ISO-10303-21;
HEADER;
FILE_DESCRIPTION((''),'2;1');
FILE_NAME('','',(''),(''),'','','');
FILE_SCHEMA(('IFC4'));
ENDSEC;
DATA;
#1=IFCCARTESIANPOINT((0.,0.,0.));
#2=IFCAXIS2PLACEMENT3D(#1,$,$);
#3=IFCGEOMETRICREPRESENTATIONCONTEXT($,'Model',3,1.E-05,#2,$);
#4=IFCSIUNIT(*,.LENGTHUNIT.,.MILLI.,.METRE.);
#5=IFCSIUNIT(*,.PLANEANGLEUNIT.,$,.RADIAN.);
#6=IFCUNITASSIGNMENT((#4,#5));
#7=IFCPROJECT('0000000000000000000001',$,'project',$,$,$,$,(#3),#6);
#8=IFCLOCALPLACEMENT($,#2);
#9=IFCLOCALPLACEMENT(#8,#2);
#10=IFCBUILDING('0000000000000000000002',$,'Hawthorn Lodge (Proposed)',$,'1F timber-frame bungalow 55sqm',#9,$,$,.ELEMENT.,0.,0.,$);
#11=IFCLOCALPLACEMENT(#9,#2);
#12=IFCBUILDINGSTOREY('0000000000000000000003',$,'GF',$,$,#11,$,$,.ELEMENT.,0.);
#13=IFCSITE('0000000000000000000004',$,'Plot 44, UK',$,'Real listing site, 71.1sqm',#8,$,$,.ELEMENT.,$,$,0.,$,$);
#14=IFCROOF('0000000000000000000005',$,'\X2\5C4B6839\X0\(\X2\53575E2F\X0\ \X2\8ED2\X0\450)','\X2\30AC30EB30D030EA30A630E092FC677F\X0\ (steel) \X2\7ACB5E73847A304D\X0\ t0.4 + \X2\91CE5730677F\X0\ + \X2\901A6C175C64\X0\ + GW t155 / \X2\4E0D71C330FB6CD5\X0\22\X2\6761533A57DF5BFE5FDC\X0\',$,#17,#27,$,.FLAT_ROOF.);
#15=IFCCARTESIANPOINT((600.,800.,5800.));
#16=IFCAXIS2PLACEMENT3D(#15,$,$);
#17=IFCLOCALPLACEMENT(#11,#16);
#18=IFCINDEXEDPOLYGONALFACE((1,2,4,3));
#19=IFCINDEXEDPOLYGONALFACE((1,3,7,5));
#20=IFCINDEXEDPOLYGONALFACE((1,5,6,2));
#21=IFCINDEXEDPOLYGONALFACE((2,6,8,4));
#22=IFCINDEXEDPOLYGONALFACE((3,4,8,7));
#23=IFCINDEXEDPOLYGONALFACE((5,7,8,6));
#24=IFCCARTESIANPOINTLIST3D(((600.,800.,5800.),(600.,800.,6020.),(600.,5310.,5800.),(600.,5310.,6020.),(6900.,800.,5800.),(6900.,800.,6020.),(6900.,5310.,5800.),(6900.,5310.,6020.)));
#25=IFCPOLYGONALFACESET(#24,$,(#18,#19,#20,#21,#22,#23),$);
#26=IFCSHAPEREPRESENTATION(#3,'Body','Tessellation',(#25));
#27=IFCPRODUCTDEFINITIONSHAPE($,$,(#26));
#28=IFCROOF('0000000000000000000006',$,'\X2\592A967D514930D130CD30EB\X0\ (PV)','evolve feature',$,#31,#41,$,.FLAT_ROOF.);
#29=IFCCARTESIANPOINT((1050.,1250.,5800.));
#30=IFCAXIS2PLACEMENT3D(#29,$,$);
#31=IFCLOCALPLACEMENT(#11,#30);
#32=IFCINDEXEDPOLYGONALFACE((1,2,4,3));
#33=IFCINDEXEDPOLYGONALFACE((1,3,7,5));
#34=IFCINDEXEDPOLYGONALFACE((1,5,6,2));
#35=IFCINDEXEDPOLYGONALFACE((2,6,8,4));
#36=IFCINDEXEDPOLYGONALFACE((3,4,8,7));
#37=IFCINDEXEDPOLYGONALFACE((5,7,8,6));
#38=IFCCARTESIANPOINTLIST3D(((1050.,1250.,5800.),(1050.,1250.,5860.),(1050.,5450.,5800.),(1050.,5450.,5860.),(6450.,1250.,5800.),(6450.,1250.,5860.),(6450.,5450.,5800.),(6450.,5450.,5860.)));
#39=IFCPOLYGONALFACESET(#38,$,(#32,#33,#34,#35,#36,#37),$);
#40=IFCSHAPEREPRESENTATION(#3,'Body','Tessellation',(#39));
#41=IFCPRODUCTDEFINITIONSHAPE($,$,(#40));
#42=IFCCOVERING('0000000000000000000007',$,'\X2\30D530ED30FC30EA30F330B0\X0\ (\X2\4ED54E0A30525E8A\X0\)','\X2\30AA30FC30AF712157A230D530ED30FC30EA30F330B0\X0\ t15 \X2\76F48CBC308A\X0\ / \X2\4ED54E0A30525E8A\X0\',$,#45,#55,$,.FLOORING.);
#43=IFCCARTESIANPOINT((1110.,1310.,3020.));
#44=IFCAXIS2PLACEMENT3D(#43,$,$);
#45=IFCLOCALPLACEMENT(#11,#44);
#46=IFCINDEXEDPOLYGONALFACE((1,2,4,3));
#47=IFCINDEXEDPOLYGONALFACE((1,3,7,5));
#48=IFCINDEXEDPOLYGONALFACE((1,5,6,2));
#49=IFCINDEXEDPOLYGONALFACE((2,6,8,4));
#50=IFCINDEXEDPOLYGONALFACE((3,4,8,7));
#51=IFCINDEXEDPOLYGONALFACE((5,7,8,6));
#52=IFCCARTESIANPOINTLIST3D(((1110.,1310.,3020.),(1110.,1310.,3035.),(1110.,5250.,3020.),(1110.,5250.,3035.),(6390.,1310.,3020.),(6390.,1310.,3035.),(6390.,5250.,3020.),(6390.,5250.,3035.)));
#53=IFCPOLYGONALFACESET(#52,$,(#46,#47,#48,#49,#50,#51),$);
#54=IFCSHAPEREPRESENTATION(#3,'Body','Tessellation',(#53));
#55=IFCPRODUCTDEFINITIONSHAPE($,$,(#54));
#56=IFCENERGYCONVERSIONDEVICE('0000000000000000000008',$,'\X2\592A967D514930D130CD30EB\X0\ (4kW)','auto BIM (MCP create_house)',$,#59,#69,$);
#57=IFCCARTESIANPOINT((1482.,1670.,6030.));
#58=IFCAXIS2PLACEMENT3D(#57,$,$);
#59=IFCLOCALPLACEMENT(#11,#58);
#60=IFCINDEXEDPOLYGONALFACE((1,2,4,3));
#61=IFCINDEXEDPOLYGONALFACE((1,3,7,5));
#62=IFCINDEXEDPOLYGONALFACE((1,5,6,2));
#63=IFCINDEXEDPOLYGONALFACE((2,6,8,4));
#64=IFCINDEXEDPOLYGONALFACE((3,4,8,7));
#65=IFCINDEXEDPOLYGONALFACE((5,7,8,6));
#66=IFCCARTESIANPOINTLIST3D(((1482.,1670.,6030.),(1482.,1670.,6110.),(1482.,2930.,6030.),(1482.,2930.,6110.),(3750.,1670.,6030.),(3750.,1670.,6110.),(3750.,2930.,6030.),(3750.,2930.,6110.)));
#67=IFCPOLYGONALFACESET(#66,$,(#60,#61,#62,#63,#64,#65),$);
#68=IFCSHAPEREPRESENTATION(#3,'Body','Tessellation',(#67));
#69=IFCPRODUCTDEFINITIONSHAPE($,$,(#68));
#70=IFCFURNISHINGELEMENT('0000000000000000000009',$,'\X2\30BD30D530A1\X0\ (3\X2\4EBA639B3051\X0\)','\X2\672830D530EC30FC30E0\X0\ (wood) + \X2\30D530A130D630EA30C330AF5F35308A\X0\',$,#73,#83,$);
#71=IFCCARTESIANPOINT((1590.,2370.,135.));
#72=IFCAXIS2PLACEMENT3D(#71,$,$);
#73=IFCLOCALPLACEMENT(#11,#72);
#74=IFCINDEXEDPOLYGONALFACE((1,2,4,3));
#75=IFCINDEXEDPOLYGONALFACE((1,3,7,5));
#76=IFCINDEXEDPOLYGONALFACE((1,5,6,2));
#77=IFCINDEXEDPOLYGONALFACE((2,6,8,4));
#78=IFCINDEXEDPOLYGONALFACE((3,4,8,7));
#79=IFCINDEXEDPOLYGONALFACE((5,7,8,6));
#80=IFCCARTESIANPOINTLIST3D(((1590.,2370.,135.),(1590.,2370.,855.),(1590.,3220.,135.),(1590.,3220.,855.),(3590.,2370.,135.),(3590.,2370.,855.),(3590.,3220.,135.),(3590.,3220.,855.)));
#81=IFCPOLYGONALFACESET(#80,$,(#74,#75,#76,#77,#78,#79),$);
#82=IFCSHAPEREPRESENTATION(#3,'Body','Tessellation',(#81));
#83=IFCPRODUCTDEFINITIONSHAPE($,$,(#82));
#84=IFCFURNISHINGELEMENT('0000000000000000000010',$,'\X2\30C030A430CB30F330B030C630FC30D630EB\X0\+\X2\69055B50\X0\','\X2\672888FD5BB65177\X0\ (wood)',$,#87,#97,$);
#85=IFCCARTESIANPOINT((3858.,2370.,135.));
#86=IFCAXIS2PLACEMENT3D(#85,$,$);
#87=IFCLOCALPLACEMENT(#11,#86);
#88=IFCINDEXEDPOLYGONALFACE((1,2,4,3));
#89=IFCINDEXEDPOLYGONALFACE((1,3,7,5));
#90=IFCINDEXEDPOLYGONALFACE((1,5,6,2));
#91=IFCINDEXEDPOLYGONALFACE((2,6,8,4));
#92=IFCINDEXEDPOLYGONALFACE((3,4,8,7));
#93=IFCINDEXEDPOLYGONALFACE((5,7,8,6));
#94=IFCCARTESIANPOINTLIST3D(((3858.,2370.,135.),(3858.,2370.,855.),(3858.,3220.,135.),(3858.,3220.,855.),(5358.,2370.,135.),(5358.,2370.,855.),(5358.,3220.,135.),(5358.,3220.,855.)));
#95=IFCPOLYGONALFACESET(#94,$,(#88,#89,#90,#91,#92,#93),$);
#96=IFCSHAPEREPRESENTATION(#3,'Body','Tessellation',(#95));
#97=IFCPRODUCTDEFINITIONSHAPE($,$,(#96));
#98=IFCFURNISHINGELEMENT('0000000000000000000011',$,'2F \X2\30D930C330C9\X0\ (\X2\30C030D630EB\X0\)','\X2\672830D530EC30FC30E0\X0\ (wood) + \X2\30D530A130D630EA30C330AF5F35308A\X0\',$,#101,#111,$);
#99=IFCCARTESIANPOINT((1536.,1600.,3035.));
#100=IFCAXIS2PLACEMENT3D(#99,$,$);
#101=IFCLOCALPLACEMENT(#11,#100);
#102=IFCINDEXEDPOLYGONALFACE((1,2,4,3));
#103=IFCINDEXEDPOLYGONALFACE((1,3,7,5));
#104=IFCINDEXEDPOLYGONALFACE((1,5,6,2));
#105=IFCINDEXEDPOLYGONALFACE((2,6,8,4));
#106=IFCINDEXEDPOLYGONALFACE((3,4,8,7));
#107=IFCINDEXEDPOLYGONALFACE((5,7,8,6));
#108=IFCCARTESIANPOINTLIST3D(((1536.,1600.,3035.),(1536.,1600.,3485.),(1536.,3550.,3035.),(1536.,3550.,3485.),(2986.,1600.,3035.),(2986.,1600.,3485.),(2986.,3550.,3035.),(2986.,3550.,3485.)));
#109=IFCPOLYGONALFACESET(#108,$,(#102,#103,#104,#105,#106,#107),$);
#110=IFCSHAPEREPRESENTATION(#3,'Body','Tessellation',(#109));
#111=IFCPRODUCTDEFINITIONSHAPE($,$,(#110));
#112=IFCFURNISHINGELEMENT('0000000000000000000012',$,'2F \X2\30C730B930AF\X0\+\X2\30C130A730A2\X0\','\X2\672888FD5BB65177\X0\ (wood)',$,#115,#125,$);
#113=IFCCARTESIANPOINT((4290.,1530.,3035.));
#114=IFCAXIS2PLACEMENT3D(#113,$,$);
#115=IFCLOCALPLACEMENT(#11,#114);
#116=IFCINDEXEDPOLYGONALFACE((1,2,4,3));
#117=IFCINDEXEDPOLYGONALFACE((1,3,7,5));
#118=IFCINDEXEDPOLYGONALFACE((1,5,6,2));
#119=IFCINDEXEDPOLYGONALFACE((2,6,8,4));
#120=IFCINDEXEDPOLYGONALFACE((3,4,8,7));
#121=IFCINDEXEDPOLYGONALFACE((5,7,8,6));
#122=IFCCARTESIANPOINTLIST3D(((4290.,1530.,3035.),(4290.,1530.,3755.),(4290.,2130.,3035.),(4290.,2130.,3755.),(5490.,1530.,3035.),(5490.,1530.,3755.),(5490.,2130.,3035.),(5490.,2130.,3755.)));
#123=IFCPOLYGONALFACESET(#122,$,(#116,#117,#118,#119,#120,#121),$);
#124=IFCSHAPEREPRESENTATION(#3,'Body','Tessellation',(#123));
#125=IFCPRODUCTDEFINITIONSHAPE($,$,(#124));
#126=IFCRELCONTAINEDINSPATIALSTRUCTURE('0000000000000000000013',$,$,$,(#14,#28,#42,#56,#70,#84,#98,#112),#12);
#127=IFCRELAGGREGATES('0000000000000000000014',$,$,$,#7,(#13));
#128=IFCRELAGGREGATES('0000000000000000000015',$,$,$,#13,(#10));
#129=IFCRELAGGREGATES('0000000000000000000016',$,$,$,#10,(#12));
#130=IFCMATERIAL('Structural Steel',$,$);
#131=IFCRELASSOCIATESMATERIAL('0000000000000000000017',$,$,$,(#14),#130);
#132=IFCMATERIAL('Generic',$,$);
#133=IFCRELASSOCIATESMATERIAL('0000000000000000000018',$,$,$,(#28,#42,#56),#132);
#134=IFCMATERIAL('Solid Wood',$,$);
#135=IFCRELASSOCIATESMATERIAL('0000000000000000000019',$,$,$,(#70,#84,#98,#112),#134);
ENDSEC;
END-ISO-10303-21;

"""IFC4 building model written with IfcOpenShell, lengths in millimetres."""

from ifc_helpers import new_model, si_unit, frame, frame_2d, origin, place, context, project, spatial, rectangle, extrude, material, element, save


model = new_model("IFC4")

# Units and contexts
model_context = context("Model", 3, precision=1e-05, world=origin())
ifc_project = project(units=[si_unit("LENGTHUNIT", "METRE", prefix="MILLI"), si_unit("PLANEANGLEUNIT", "RADIAN")], contexts=[model_context])

# Site, building, storey
site_placement = place(None, origin())
site = spatial("IfcSite", under=ifc_project, at=site_placement, Name="Plot 44, UK", ObjectType="Real listing site, 71.1sqm", CompositionType="ELEMENT", RefElevation=0.0)
building_placement = place(site_placement, origin())
building = spatial("IfcBuilding", under=site, at=building_placement, Name="Hawthorn Lodge (Proposed)", ObjectType="1F timber-frame bungalow 55sqm", CompositionType="ELEMENT", ElevationOfRefHeight=0.0, ElevationOfTerrain=0.0)
storey_placement = place(building_placement, origin())
storey = spatial("IfcBuildingStorey", under=building, at=storey_placement, Name="GF", CompositionType="ELEMENT", Elevation=0.0)

# Shared definitions
ifc_material_1 = material(Name="Solid Wood")

# Shared definitions
ifc_material_2 = material(Name="Generic")

# Roofs
ifc_material_3 = material(Name="Structural Steel")
for number, where, name in (
    (1, (600.0, 800.0, 5800.0), "屋根(南帯 軒450)"),
):
    element("IfcRoof", number, at=place(storey_placement, frame(where)), inside=storey, material=ifc_material_3, Name=name, Description="ガルバリウム鋼板 (steel) 立平葺き t0.4 + 野地板 + 通気層 + GW t155 / 不燃・法22条区域対応", PredefinedType="FLAT_ROOF", context=model_context, shape_type="SweptSolid", body=[
        extrude(rectangle(XDim=6300.0, YDim=4510.0, at=frame_2d((3150.0, 2255.0))), frame((600.0, 800.0, 5800.0)), (0.0, 0.0, 1.0), 220.0),
    ])
roof_placement = place(storey_placement, frame((1050.0, 1250.0, 5800.0)))
element("IfcRoof", 2, at=roof_placement, inside=storey, material=ifc_material_2, Name="太陽光パネル (PV)", Description="evolve feature", PredefinedType="FLAT_ROOF", context=model_context, shape_type="SweptSolid", body=[
    extrude(rectangle(XDim=5400.0, YDim=4200.0, at=frame_2d((2700.0, 2100.0))), frame((1050.0, 1250.0, 5800.0)), (0.0, 0.0, 1.0), 60.0),
])

# Covering
covering_placement = place(storey_placement, frame((1110.0, 1310.0, 3020.0)))
element("IfcCovering", 3, at=covering_placement, inside=storey, material=ifc_material_2, Name="フローリング (仕上げ床)", Description="オーク無垢フローリング t15 直貼り / 仕上げ床", PredefinedType="FLOORING", context=model_context, shape_type="SweptSolid", body=[
    extrude(rectangle(XDim=5280.0, YDim=3940.0, at=frame_2d((2640.0, 1970.0))), frame((1110.0, 1310.0, 3020.0)), (0.0, 0.0, 1.0), 15.0),
])

# Energy conversion device
energy_conversion_device_placement = place(storey_placement, frame((1482.0, 1670.0, 6030.0)))
element("IfcEnergyConversionDevice", 4, at=energy_conversion_device_placement, inside=storey, material=ifc_material_2, Name="太陽光パネル (4kW)", Description="auto BIM (MCP create_house)", context=model_context, shape_type="SweptSolid", body=[
    extrude(rectangle(XDim=2268.0, YDim=1260.0, at=frame_2d((1134.0, 630.0))), frame((1482.0, 1670.0, 6030.0)), (0.0, 0.0, 1.0), 80.0),
])

# Furnishing elements
furnishing_1_placement = place(storey_placement, frame((1590.0, 2370.0, 135.0)))
element("IfcFurnishingElement", 5, at=furnishing_1_placement, inside=storey, material=ifc_material_1, Name="ソファ (3人掛け)", Description="木フレーム (wood) + ファブリック張り", context=model_context, shape_type="SweptSolid", body=[
    extrude(rectangle(XDim=2000.0, YDim=850.0, at=frame_2d((1000.0, 425.0))), frame((1590.0, 2370.0, 135.0)), (0.0, 0.0, 1.0), 720.0),
])
furnishing_2_placement = place(storey_placement, frame((3858.0, 2370.0, 135.0)))
element("IfcFurnishingElement", 6, at=furnishing_2_placement, inside=storey, material=ifc_material_1, Name="ダイニングテーブル+椅子", Description="木製家具 (wood)", context=model_context, shape_type="SweptSolid", body=[
    extrude(rectangle(XDim=1500.0, YDim=850.0, at=frame_2d((750.0, 425.0))), frame((3858.0, 2370.0, 135.0)), (0.0, 0.0, 1.0), 720.0),
])
furnishing_3_placement = place(storey_placement, frame((1536.0, 1600.0, 3035.0)))
element("IfcFurnishingElement", 7, at=furnishing_3_placement, inside=storey, material=ifc_material_1, Name="2F ベッド (ダブル)", Description="木フレーム (wood) + ファブリック張り", context=model_context, shape_type="SweptSolid", body=[
    extrude(rectangle(XDim=1450.0, YDim=1950.0, at=frame_2d((725.0, 975.0))), frame((1536.0, 1600.0, 3035.0)), (0.0, 0.0, 1.0), 450.0),
])
furnishing_4_placement = place(storey_placement, frame((4290.0, 1530.0, 3035.0)))
element("IfcFurnishingElement", 8, at=furnishing_4_placement, inside=storey, material=ifc_material_1, Name="2F デスク+チェア", Description="木製家具 (wood)", context=model_context, shape_type="SweptSolid", body=[
    extrude(rectangle(XDim=1200.0, YDim=600.0, at=frame_2d((600.0, 300.0))), frame((4290.0, 1530.0, 3035.0)), (0.0, 0.0, 1.0), 720.0),
])

save(model, "model.ifc")
